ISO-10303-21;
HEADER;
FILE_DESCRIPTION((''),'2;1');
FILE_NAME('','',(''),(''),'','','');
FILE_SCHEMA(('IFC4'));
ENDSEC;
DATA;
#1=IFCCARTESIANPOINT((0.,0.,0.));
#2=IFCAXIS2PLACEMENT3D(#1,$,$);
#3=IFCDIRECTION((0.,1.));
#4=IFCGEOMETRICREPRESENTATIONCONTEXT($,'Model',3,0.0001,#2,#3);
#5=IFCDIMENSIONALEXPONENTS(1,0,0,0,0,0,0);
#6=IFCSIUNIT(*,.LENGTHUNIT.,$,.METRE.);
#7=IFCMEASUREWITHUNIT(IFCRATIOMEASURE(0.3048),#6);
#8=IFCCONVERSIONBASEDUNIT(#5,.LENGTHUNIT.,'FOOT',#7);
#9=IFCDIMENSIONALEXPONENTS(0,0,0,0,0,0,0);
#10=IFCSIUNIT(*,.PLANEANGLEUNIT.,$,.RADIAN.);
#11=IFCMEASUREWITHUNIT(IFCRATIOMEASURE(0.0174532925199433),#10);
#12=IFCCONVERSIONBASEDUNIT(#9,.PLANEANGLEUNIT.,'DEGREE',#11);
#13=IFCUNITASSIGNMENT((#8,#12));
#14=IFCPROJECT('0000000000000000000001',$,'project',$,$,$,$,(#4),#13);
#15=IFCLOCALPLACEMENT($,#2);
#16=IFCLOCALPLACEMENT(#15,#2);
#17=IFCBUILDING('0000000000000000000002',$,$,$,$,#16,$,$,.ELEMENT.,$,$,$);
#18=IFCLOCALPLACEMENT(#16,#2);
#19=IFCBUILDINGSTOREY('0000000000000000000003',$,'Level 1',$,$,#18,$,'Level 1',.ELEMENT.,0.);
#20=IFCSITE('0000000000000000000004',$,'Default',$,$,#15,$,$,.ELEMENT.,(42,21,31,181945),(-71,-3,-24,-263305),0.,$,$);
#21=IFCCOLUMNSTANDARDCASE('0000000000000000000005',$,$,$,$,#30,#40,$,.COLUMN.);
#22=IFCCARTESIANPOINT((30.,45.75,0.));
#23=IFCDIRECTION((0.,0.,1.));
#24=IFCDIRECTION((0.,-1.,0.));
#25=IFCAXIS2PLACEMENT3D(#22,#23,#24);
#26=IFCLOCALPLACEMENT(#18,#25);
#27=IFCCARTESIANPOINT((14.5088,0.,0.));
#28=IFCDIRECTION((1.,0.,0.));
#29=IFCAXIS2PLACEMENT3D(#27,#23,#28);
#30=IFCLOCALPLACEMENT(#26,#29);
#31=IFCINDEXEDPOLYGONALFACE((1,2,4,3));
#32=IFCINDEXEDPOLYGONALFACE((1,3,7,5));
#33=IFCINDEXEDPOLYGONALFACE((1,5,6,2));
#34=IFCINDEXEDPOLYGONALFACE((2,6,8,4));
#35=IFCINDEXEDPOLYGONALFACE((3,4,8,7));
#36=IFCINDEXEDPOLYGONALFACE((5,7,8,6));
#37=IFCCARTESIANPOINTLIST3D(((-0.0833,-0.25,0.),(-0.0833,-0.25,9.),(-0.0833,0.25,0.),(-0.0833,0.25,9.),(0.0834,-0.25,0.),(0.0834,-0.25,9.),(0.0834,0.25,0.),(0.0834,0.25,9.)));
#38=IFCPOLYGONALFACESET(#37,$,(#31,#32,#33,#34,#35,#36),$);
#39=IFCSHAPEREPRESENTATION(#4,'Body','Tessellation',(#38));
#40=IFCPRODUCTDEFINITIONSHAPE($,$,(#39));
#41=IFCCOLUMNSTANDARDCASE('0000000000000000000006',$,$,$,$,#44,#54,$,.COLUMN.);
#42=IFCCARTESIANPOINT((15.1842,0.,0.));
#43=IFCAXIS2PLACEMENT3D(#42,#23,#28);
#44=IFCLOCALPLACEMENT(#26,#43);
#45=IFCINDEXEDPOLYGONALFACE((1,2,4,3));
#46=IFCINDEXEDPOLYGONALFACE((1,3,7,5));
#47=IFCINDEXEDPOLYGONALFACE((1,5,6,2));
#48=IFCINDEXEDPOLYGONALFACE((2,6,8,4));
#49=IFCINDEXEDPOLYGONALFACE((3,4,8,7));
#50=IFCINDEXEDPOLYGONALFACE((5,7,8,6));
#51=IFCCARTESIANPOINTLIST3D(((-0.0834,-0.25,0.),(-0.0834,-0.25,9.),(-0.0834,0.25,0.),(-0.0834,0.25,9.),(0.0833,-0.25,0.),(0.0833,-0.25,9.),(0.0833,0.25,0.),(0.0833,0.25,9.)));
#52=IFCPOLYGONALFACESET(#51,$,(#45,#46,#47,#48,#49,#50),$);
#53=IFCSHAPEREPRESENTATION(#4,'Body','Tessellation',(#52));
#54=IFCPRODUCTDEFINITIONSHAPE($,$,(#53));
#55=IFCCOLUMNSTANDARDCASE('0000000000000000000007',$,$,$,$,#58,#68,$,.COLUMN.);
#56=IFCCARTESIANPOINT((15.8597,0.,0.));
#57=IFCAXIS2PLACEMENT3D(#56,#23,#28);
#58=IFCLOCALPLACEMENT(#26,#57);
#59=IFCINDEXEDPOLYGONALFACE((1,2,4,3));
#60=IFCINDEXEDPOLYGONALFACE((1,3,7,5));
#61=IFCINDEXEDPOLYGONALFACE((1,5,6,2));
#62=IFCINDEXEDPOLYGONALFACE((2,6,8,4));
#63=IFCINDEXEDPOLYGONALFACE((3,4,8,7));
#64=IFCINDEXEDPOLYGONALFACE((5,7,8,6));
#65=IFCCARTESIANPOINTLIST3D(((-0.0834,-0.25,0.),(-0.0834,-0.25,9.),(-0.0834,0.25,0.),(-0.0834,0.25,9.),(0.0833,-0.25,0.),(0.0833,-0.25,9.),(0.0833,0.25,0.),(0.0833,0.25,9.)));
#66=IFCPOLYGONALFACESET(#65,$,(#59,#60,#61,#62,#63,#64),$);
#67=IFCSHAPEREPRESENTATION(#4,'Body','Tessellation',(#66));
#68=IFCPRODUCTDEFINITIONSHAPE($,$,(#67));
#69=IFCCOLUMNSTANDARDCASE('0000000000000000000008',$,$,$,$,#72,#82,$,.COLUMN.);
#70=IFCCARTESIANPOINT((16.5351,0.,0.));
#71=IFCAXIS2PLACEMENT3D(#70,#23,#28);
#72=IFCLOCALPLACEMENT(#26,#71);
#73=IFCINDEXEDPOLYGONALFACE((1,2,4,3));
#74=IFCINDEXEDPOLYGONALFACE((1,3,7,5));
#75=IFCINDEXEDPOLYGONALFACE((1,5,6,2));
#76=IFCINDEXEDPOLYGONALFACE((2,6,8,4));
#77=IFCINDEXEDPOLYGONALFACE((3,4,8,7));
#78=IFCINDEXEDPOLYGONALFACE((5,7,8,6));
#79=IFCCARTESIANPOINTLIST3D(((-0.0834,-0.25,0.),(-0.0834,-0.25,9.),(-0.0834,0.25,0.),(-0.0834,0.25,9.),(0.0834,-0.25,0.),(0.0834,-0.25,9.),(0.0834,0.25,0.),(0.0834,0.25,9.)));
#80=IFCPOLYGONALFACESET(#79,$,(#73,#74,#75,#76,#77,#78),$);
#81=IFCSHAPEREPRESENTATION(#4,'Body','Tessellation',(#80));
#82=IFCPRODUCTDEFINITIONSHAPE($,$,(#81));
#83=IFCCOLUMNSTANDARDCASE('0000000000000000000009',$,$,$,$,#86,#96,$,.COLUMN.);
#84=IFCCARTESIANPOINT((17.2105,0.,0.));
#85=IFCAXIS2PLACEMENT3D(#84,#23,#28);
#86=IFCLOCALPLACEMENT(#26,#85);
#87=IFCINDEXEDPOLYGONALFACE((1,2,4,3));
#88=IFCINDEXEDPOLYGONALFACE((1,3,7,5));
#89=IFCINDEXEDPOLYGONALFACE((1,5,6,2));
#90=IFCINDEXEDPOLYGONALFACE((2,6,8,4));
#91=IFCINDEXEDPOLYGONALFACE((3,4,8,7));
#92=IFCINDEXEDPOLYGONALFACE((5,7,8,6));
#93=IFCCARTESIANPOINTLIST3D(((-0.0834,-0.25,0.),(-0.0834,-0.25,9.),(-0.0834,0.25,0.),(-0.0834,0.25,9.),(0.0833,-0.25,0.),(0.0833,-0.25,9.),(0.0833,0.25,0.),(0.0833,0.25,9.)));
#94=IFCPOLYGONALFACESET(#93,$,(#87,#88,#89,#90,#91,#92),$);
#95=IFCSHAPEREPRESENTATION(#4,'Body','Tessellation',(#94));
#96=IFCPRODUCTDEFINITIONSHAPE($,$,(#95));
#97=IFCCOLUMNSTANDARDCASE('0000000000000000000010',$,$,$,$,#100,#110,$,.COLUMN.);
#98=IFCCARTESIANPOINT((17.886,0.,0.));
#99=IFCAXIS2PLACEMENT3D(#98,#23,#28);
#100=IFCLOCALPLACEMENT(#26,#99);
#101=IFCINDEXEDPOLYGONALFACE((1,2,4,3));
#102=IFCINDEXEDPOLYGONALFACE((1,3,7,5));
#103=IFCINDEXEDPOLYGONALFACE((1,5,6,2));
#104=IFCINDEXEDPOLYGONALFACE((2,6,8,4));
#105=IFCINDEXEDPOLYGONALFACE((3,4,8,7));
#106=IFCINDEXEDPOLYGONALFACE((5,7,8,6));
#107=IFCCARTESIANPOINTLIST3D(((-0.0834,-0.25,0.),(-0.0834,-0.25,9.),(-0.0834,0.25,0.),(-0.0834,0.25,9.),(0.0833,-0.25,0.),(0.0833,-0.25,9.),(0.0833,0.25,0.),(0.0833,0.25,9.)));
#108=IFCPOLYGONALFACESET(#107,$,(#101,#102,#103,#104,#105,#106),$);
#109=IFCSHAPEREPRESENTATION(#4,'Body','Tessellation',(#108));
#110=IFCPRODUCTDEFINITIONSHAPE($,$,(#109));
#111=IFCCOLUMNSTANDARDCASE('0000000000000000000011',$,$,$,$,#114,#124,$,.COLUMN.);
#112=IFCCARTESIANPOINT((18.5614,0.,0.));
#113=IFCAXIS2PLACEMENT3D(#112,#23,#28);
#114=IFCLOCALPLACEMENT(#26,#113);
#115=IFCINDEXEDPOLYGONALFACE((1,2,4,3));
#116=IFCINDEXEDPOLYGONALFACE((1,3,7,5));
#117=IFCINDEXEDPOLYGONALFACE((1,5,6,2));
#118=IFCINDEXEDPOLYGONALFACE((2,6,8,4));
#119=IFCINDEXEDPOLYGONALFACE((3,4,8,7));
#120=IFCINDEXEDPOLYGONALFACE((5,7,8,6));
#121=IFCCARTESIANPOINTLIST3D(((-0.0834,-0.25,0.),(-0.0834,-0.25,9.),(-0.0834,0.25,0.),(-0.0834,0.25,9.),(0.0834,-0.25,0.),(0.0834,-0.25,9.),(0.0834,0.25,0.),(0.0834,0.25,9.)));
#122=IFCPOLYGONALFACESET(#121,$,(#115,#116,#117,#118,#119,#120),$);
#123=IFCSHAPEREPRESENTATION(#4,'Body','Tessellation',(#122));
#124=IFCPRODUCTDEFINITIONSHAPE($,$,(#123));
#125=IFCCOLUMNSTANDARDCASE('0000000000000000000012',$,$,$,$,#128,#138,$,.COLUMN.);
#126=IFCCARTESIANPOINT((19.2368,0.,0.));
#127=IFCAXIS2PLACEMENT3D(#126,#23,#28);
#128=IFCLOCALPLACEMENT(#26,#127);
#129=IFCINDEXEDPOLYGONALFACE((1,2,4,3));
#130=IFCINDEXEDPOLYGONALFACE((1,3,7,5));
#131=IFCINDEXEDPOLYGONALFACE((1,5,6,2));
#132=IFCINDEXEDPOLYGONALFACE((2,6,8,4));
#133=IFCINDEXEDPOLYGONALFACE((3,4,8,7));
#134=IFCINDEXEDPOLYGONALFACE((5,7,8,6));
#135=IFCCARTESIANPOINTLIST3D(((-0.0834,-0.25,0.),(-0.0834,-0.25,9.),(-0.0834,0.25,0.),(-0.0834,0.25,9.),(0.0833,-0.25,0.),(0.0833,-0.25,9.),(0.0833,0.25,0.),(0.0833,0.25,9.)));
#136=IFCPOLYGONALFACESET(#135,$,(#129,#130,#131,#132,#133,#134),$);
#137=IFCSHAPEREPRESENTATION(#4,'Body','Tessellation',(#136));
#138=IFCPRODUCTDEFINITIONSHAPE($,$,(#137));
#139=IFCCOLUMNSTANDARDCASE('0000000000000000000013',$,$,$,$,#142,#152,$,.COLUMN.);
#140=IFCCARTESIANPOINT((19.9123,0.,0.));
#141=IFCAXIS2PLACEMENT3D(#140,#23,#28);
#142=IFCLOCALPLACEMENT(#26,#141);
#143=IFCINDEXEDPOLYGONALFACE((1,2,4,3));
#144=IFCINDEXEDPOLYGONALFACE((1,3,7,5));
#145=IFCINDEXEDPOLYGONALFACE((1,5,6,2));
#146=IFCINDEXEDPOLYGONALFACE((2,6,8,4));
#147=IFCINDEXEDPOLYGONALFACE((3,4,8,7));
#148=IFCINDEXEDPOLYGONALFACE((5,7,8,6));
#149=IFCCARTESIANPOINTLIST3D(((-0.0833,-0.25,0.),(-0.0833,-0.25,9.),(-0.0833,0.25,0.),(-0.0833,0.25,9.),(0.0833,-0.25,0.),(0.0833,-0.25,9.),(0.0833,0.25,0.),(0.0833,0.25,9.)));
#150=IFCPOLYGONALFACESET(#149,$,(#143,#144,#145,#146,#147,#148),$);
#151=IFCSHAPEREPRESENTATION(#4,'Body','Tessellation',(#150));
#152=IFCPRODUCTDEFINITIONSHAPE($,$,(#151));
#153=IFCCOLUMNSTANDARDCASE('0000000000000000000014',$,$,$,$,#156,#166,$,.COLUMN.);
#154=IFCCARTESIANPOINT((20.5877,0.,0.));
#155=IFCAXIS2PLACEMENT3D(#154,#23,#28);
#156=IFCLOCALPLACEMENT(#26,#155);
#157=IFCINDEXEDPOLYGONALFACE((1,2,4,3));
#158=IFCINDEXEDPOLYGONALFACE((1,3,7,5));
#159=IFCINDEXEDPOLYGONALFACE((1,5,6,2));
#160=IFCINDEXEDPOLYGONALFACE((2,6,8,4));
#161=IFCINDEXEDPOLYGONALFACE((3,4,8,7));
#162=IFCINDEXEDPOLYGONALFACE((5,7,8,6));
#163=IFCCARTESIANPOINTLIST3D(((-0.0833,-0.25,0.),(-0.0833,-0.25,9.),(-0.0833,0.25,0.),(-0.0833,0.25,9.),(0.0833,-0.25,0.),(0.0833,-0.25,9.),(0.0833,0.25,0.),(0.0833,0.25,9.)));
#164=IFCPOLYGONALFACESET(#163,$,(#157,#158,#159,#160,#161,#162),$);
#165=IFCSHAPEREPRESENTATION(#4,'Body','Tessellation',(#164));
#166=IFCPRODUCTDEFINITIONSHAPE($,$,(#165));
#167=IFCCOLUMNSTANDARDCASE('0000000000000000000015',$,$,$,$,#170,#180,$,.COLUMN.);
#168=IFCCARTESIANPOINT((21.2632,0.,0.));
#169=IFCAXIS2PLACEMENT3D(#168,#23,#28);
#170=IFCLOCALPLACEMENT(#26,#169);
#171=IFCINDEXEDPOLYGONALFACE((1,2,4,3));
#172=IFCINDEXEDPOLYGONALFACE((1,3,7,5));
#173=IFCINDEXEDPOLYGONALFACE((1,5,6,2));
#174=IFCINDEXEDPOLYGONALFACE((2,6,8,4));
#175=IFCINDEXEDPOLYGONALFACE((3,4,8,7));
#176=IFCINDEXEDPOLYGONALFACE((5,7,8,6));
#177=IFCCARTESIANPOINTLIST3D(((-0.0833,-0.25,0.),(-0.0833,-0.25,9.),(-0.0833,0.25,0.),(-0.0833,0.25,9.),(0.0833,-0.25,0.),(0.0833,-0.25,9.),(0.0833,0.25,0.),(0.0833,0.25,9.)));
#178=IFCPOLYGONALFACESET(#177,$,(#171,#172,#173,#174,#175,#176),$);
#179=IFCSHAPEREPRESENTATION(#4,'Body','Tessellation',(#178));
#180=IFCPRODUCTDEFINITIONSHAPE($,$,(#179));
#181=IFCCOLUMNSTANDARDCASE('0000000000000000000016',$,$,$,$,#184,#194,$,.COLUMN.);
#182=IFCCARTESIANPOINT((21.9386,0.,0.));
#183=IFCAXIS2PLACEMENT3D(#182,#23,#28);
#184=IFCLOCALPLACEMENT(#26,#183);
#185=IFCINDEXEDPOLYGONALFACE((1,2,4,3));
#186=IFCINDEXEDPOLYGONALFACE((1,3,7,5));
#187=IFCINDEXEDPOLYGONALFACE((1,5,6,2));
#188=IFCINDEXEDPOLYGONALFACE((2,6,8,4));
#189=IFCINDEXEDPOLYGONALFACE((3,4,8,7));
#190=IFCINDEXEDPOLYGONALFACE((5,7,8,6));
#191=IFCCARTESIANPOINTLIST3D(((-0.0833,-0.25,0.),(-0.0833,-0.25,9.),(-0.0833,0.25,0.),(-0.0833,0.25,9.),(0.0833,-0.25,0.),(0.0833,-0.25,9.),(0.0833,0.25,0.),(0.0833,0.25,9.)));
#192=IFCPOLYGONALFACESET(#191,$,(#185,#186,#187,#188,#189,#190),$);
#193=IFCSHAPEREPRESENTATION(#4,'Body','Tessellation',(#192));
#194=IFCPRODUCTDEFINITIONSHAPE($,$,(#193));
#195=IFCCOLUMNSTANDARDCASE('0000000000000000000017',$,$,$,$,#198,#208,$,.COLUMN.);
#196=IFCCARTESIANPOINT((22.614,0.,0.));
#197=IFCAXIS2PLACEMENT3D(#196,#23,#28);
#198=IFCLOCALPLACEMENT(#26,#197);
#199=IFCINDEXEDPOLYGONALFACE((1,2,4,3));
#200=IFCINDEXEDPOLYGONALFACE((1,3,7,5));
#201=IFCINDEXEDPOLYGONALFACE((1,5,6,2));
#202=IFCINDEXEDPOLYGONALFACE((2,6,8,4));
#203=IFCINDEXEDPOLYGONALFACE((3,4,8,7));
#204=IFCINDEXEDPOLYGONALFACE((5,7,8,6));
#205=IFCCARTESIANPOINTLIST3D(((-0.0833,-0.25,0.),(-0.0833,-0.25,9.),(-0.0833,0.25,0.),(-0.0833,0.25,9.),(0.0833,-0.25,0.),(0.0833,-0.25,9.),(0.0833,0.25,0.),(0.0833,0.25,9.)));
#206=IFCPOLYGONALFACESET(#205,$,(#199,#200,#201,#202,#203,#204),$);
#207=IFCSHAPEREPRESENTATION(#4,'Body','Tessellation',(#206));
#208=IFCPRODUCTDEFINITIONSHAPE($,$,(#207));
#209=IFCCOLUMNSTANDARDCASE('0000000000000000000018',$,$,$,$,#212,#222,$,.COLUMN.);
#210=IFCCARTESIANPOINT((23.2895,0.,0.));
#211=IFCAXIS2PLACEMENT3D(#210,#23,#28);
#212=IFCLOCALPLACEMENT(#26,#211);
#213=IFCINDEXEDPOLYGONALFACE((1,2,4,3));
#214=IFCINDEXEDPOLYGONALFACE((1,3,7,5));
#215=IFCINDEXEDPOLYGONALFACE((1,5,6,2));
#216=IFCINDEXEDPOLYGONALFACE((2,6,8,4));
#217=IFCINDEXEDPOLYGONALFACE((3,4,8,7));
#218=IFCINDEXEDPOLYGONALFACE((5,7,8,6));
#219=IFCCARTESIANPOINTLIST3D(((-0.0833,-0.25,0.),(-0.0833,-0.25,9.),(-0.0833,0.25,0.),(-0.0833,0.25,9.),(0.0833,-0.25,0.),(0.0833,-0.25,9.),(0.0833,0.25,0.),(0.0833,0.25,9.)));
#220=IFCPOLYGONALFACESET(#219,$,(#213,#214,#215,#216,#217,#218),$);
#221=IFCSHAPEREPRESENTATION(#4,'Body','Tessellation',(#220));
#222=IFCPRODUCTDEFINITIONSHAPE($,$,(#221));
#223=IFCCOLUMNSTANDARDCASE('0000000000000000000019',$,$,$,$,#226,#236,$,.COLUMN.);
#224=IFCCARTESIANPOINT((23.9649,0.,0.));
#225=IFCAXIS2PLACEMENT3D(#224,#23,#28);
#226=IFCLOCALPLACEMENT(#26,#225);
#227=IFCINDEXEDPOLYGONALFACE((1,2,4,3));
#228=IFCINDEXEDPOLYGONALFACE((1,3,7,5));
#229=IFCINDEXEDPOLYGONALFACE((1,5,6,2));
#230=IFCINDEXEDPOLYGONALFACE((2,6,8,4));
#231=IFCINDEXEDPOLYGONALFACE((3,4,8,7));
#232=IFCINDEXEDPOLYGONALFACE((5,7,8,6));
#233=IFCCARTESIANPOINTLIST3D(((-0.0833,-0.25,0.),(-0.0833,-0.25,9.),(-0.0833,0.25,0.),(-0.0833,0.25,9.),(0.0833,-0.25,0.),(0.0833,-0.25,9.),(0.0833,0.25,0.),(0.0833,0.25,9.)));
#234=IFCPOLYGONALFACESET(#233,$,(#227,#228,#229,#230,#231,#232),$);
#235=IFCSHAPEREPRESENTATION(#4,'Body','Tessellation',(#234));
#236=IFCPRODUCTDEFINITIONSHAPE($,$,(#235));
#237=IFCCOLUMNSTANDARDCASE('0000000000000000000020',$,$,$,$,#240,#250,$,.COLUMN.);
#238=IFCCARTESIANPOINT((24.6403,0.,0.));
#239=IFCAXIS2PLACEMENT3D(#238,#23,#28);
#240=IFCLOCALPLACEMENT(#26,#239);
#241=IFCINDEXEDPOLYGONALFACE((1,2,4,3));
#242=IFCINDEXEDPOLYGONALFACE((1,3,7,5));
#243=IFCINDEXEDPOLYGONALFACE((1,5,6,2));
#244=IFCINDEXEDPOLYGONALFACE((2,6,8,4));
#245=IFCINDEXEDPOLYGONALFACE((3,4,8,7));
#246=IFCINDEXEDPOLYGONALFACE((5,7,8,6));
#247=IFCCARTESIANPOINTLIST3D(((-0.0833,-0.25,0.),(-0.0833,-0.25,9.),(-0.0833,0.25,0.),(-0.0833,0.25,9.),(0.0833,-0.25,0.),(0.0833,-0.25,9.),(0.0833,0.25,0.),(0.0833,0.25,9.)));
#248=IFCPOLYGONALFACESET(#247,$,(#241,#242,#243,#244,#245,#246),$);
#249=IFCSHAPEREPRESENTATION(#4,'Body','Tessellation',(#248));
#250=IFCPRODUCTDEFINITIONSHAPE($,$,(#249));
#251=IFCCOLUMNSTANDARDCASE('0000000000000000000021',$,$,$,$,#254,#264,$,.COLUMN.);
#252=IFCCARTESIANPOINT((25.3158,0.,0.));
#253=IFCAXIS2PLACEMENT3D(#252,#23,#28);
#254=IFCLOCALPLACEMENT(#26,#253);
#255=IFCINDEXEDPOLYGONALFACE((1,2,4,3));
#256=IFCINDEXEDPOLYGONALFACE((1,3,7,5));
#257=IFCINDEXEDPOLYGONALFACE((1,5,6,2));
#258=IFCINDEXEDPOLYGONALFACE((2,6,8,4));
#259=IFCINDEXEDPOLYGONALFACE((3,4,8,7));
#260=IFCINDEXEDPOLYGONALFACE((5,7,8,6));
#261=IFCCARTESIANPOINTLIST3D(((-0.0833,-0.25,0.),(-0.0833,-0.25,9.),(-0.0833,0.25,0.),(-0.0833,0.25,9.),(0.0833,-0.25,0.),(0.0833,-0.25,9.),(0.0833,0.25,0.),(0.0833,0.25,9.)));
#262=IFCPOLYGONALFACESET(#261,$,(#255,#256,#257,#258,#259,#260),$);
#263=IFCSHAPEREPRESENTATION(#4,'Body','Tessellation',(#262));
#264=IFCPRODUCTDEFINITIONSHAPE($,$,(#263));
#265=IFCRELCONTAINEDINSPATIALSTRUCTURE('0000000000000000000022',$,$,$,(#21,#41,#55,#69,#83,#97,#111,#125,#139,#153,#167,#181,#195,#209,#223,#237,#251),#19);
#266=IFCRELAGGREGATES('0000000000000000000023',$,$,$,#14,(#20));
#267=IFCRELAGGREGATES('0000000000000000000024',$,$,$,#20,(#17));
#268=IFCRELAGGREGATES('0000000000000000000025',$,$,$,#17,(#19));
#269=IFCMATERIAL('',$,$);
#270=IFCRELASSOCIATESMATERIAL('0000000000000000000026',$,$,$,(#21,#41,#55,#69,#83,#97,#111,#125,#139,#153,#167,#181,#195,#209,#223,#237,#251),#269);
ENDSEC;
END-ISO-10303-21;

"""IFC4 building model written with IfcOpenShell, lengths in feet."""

from ifc_helpers import new_model, entity, si_unit, converted_unit, direction, frame, origin, place, context, project, spatial, rectangle, extrude, material, element, save


model = new_model("IFC4")

# Units and contexts
model_context = context("Model", 3, precision=0.0001, world=origin(), true_north=direction((0.0, 1.0)))
ifc_project = project(units=[converted_unit("LENGTHUNIT", "FOOT", entity("IfcRatioMeasure", 0.3048), si_unit("LENGTHUNIT", "METRE"), dimensions=[1, 0, 0, 0, 0, 0, 0]), converted_unit("PLANEANGLEUNIT", "DEGREE", entity("IfcRatioMeasure", 0.0174532925199433), si_unit("PLANEANGLEUNIT", "RADIAN"), dimensions=[0, 0, 0, 0, 0, 0, 0])], contexts=[model_context])

# Site, building, storey
site_placement = place(None, origin())
site = spatial("IfcSite", under=ifc_project, at=site_placement, Name="Default", CompositionType="ELEMENT", RefLatitude=(42, 21, 31, 181945), RefLongitude=(-71, -3, -24, -263305), RefElevation=0.0)
building_placement = place(site_placement, origin())
building = spatial("IfcBuilding", under=site, at=building_placement, CompositionType="ELEMENT")
storey_placement = place(building_placement, origin())
storey = spatial("IfcBuildingStorey", under=building, at=storey_placement, Name="Level 1", LongName="Level 1", CompositionType="ELEMENT", Elevation=0.0)

# Columns
ifc_material_1 = material(Name="")
placement_1 = place(storey_placement, frame((30.0, 45.75, 0.0), z_axis=(0.0, 0.0, 1.0), x_axis=(0.0, -1.0, 0.0)))
for number, where, z_axis, x_axis in (
    (1, (14.5088, 0.0, 0.0), (0.0, 0.0, 1.0), (1.0, 0.0, 0.0)),
    (2, (15.1842, 0.0, 0.0), (0.0, 0.0, 1.0), (1.0, 0.0, 0.0)),
    (3, (15.8597, 0.0, 0.0), (0.0, 0.0, 1.0), (1.0, 0.0, 0.0)),
    (4, (16.5351, 0.0, 0.0), (0.0, 0.0, 1.0), (1.0, 0.0, 0.0)),
    (5, (17.2105, 0.0, 0.0), (0.0, 0.0, 1.0), (1.0, 0.0, 0.0)),
    (6, (17.886, 0.0, 0.0), (0.0, 0.0, 1.0), (1.0, 0.0, 0.0)),
    (7, (18.5614, 0.0, 0.0), (0.0, 0.0, 1.0), (1.0, 0.0, 0.0)),
    (8, (19.2368, 0.0, 0.0), (0.0, 0.0, 1.0), (1.0, 0.0, 0.0)),
    (9, (19.9123, 0.0, 0.0), (0.0, 0.0, 1.0), (1.0, 0.0, 0.0)),
    (10, (20.5877, 0.0, 0.0), (0.0, 0.0, 1.0), (1.0, 0.0, 0.0)),
    (11, (21.2632, 0.0, 0.0), (0.0, 0.0, 1.0), (1.0, 0.0, 0.0)),
    (12, (21.9386, 0.0, 0.0), (0.0, 0.0, 1.0), (1.0, 0.0, 0.0)),
    (13, (22.614, 0.0, 0.0), (0.0, 0.0, 1.0), (1.0, 0.0, 0.0)),
    (14, (23.2895, 0.0, 0.0), (0.0, 0.0, 1.0), (1.0, 0.0, 0.0)),
    (15, (23.9649, 0.0, 0.0), (0.0, 0.0, 1.0), (1.0, 0.0, 0.0)),
    (16, (24.6403, 0.0, 0.0), (0.0, 0.0, 1.0), (1.0, 0.0, 0.0)),
    (17, (25.3158, 0.0, 0.0), (0.0, 0.0, 1.0), (1.0, 0.0, 0.0)),
):
    element("IfcColumnStandardCase", number, at=place(placement_1, frame(where, z_axis=z_axis, x_axis=x_axis)), inside=storey, material=ifc_material_1, PredefinedType="COLUMN", context=model_context, shape_type="SweptSolid", body=[
        extrude(rectangle(XDim=0.1667, YDim=0.5), origin(), (0.0, 0.0, 1.0), 9.0),
    ])

save(model, "model.ifc")
